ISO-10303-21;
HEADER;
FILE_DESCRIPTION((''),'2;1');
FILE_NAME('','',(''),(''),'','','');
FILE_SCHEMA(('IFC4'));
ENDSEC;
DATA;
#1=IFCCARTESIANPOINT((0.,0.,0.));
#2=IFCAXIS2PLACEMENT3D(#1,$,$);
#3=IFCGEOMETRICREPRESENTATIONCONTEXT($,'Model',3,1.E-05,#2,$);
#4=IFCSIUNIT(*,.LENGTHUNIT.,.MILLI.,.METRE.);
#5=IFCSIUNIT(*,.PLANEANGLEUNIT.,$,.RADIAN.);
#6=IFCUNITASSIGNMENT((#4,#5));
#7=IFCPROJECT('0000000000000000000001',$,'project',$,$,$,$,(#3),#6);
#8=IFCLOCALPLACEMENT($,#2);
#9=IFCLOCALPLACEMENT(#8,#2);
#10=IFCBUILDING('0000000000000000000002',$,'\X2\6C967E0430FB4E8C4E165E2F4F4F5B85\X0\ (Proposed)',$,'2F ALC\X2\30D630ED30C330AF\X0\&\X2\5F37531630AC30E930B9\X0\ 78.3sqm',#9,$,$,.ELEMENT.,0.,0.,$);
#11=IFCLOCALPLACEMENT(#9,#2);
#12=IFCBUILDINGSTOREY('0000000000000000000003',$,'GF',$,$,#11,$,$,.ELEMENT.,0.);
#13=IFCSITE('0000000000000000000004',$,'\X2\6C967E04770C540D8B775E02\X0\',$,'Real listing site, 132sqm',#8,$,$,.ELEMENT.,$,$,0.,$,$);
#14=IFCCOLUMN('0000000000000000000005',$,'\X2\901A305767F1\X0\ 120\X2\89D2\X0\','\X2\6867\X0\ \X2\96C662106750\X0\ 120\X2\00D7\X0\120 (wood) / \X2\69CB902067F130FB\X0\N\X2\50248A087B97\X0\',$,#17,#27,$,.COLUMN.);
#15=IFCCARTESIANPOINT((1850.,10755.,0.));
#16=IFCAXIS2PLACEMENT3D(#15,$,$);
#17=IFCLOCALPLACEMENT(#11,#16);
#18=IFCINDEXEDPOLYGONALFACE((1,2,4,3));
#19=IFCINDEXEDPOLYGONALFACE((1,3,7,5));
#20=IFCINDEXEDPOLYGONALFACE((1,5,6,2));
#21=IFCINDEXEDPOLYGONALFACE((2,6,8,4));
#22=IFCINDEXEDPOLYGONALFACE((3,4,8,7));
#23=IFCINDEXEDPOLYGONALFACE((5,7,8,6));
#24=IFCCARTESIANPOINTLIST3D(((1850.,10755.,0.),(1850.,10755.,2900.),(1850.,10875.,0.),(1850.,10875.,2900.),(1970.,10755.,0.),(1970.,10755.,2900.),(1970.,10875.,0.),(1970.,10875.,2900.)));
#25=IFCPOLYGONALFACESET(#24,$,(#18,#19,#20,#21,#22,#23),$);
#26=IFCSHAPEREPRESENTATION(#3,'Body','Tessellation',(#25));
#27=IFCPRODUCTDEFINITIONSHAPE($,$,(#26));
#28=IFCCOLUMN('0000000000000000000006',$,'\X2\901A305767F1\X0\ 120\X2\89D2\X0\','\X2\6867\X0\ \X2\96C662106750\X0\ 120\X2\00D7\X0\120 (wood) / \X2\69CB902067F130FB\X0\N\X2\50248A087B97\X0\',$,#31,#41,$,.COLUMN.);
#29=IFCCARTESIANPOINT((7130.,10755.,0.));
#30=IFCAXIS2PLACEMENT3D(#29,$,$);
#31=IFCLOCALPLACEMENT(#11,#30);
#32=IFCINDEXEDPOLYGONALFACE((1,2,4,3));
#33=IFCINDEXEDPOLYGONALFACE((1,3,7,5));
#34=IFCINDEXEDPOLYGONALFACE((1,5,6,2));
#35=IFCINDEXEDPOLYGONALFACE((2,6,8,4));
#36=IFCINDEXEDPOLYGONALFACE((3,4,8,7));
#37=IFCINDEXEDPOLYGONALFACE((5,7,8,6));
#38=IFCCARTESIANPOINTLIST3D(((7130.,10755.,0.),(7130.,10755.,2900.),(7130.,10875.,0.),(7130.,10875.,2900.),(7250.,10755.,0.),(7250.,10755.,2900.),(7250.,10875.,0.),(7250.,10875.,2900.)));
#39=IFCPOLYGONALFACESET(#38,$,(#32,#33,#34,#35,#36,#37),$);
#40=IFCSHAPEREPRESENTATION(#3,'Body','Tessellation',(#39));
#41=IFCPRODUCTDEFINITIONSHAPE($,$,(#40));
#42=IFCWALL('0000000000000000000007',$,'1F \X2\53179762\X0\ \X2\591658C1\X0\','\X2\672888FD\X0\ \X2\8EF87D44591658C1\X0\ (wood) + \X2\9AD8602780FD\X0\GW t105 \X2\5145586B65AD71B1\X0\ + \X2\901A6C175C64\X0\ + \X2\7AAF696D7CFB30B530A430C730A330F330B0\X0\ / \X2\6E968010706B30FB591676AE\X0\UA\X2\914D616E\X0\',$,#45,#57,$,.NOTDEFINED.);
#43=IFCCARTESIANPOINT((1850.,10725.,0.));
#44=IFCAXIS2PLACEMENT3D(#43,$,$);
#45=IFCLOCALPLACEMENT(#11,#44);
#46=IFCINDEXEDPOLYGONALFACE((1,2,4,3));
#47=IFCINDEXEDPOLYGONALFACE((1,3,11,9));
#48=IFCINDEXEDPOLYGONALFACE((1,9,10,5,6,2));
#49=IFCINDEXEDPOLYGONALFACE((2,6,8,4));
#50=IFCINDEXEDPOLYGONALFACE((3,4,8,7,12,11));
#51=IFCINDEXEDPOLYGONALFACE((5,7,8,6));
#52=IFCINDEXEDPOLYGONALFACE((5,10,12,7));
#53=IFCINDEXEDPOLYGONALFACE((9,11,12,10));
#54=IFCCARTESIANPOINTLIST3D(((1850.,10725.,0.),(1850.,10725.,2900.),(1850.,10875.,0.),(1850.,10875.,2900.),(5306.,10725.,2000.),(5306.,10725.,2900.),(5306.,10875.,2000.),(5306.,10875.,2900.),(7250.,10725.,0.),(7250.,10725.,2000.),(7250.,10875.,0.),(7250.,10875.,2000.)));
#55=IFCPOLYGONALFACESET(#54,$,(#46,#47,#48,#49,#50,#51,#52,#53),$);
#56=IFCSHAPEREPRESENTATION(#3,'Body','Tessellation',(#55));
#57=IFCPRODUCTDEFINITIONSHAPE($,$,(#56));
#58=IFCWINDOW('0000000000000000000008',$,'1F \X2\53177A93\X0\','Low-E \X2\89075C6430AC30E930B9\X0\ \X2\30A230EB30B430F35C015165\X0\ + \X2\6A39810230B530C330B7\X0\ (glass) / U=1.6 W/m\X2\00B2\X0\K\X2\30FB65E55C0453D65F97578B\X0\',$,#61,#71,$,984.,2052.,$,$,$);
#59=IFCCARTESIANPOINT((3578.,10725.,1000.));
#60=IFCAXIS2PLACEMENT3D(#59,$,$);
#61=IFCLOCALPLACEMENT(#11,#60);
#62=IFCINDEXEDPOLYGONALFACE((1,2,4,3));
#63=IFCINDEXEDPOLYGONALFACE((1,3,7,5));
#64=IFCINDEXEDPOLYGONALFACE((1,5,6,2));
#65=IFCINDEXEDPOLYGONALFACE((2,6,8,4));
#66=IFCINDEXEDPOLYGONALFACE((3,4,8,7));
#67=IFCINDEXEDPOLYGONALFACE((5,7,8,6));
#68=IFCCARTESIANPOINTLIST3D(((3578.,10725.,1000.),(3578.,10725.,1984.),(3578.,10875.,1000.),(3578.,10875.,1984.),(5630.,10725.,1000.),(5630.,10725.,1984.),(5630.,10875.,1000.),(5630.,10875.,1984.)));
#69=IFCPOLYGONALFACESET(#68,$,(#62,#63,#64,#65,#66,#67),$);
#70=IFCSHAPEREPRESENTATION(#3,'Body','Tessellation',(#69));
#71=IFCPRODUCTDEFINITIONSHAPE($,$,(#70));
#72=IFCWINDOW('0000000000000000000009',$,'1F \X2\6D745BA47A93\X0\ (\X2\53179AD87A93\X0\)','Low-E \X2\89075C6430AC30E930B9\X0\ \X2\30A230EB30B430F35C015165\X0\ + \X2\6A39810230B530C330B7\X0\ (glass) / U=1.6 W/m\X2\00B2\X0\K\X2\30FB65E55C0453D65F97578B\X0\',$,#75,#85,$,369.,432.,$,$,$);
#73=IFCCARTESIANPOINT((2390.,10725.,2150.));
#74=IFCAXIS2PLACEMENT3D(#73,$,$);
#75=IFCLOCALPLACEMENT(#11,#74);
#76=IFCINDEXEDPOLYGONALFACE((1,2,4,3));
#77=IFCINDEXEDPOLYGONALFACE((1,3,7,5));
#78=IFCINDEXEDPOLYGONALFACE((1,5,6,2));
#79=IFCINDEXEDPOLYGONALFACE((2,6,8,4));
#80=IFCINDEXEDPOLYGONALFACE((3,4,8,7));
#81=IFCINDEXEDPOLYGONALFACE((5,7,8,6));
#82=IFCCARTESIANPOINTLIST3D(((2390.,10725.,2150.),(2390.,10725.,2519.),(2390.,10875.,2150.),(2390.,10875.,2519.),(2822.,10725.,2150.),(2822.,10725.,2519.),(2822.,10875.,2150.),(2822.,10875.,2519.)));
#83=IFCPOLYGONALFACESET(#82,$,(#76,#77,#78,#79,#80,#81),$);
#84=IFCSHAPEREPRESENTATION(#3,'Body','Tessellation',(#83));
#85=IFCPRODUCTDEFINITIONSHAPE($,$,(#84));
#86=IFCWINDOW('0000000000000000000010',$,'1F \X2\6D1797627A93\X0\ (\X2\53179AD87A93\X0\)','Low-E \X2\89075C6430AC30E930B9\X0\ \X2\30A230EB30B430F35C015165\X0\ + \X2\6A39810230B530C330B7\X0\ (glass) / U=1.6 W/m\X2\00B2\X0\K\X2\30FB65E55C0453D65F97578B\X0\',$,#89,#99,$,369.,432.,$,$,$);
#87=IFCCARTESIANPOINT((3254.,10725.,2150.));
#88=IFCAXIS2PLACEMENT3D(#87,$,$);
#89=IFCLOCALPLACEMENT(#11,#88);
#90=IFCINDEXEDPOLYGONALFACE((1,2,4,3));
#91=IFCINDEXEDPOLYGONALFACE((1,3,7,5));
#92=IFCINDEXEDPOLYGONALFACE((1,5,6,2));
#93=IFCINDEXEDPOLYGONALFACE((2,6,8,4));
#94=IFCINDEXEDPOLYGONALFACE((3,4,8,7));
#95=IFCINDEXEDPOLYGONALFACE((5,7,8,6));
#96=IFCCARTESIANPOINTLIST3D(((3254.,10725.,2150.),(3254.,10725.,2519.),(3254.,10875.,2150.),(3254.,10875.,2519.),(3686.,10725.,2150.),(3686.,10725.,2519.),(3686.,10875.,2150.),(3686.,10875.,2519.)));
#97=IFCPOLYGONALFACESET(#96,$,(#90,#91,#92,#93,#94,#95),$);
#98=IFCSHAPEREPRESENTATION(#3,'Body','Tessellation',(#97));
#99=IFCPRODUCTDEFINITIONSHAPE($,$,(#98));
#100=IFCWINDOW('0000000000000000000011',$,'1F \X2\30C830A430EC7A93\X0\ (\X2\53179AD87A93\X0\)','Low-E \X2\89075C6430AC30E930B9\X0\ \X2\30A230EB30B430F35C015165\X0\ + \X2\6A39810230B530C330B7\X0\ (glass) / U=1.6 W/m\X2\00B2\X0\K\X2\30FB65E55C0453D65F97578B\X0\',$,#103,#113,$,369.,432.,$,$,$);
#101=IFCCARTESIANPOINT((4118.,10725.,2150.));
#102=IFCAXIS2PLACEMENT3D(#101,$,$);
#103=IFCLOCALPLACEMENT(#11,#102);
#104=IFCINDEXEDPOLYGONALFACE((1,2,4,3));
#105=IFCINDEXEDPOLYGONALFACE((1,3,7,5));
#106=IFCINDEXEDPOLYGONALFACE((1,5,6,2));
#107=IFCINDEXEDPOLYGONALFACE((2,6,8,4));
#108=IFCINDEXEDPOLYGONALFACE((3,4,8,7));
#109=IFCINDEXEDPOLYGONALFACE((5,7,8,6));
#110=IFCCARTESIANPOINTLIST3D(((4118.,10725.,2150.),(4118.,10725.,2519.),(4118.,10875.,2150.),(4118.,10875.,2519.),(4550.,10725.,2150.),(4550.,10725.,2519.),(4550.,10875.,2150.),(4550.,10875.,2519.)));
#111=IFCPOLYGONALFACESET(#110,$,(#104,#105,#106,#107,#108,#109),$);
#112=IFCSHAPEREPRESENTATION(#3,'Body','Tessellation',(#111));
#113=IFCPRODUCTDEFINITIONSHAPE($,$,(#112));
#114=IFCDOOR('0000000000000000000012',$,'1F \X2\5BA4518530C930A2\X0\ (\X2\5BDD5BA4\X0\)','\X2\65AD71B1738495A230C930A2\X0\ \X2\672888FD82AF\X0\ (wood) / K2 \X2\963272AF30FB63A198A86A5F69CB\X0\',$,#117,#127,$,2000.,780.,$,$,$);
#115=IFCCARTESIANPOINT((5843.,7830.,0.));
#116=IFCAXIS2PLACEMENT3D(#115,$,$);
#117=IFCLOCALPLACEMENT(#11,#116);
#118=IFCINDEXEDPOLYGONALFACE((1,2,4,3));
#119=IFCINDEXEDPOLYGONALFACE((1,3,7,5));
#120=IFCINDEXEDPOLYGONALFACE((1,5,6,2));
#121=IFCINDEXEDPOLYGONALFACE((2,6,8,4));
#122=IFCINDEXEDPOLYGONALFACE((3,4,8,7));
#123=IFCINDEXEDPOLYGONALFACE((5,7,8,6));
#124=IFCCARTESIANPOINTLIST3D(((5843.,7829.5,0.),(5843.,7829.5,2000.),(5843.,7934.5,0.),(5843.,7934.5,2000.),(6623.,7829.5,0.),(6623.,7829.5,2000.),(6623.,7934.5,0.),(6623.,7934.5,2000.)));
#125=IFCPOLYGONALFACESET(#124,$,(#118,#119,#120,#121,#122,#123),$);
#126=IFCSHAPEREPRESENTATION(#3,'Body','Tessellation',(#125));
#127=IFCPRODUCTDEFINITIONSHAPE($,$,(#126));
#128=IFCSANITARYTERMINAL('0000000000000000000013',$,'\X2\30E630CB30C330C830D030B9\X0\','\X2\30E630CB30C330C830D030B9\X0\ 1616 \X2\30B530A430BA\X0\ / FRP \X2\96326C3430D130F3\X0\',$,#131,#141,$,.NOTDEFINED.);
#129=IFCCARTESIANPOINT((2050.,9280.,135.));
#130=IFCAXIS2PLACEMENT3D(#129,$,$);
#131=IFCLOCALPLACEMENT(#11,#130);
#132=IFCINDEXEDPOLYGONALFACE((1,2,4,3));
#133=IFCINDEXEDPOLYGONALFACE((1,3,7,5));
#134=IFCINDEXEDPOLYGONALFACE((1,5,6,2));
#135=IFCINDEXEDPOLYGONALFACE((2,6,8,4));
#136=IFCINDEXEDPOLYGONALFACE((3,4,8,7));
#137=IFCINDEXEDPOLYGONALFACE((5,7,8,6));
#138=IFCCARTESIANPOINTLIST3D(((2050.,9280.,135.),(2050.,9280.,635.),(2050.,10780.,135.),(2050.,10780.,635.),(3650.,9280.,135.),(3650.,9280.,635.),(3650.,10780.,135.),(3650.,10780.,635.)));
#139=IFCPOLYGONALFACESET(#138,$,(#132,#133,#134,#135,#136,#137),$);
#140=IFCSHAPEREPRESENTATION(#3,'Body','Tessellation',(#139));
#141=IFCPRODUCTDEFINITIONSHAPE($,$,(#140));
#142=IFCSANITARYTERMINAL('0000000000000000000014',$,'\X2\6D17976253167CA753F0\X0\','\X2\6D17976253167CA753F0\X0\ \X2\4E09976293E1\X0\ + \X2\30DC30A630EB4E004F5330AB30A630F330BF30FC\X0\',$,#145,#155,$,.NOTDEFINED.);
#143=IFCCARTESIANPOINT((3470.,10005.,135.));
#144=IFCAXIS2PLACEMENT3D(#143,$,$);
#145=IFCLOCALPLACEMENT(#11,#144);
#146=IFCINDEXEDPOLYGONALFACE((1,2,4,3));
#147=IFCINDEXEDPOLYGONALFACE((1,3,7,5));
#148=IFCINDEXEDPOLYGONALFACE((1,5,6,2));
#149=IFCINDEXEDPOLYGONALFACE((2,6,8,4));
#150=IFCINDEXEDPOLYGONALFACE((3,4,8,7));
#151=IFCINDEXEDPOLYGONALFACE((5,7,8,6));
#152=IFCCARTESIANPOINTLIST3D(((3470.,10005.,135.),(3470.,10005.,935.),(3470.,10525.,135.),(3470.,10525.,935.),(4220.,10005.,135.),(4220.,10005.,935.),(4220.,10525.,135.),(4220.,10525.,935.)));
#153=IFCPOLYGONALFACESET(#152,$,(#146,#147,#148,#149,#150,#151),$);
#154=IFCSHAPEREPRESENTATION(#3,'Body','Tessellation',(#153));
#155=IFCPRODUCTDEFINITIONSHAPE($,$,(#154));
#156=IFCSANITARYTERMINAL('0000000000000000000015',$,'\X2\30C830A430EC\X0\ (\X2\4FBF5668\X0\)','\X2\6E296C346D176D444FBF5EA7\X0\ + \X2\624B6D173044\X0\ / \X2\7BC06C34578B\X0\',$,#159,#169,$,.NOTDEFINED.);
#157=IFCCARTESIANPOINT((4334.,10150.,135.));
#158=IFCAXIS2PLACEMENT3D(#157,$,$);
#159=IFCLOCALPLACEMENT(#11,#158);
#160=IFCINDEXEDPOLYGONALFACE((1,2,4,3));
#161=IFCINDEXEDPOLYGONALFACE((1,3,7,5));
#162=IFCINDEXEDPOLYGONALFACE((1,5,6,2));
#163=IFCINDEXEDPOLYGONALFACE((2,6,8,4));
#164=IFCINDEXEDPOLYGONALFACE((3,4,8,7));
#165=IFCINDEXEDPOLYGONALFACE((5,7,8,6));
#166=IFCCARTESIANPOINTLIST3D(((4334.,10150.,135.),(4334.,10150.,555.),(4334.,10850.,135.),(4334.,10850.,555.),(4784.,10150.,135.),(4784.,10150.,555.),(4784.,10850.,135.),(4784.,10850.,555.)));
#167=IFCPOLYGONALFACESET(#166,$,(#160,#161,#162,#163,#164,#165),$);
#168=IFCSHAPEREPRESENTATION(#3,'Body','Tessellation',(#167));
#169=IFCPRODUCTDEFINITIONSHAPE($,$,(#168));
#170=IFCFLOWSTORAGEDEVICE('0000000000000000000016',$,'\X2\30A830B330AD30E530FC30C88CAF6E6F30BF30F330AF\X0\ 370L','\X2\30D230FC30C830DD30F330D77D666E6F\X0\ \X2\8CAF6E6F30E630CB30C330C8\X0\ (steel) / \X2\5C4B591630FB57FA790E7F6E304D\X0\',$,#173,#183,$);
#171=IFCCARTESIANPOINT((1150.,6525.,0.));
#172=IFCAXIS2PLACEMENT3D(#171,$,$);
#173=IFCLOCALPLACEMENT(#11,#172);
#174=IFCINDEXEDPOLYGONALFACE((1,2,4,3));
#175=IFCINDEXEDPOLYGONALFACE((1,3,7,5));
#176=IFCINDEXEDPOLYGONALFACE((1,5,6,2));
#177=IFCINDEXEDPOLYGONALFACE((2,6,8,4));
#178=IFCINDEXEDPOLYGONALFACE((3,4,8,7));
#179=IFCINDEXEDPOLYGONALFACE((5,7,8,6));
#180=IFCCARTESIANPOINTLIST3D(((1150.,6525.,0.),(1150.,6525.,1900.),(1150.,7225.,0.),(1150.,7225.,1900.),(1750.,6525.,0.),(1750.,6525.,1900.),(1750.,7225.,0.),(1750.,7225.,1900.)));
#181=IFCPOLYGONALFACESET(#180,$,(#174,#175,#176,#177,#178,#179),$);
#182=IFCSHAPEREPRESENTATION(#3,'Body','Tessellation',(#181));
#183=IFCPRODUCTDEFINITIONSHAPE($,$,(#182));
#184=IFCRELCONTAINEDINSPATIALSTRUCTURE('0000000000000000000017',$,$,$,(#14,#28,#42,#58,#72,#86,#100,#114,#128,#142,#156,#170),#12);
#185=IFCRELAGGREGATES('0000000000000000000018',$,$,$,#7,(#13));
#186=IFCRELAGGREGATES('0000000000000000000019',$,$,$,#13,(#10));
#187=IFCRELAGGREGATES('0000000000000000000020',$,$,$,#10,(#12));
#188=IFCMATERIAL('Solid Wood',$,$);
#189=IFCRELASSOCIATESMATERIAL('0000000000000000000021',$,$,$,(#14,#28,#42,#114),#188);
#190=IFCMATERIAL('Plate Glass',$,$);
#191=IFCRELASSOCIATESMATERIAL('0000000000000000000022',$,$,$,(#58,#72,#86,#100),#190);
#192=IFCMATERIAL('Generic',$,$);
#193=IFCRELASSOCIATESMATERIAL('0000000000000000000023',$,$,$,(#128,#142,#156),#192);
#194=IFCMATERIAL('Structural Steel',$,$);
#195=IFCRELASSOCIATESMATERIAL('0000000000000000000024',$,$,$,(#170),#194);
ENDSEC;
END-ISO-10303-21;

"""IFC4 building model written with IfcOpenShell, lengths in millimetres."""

from ifc_helpers import new_model, si_unit, frame, frame_2d, origin, place, context, project, spatial, rectangle, extrude, material, element, fill, save


model = new_model("IFC4")

# Units and contexts
model_context = context("Model", 3, precision=1e-05, world=origin())
ifc_project = project(units=[si_unit("LENGTHUNIT", "METRE", prefix="MILLI"), si_unit("PLANEANGLEUNIT", "RADIAN")], contexts=[model_context])

# Site, building, storey
site_placement = place(None, origin())
site = spatial("IfcSite", under=ifc_project, at=site_placement, Name="沖縄県名護市", ObjectType="Real listing site, 132sqm", CompositionType="ELEMENT", RefElevation=0.0)
building_placement = place(site_placement, origin())
building = spatial("IfcBuilding", under=site, at=building_placement, Name="沖縄・二世帯住宅 (Proposed)", ObjectType="2F ALCブロック&強化ガラス 78.3sqm", CompositionType="ELEMENT", ElevationOfRefHeight=0.0, ElevationOfTerrain=0.0)
storey_placement = place(building_placement, origin())
storey = spatial("IfcBuildingStorey", under=building, at=storey_placement, Name="GF", CompositionType="ELEMENT", Elevation=0.0)

# Columns
ifc_material_1 = material(Name="Solid Wood")
column_1_placement = place(storey_placement, frame((1850.0, 10755.0, 0.0)))
element("IfcColumn", 1, at=column_1_placement, inside=storey, material=ifc_material_1, Name="通し柱 120角", Description="桧 集成材 120×120 (wood) / 構造柱・N値計算", PredefinedType="COLUMN", context=model_context, shape_type="SweptSolid", body=[
    extrude(rectangle(XDim=120.0, YDim=120.0, at=frame_2d((60.0, 60.0))), frame((1850.0, 10755.0, 0.0)), (0.0, 0.0, 1.0), 2900.0),
])
column_2_placement = place(storey_placement, frame((7130.0, 10755.0, 0.0)))
element("IfcColumn", 2, at=column_2_placement, inside=storey, material=ifc_material_1, Name="通し柱 120角", Description="桧 集成材 120×120 (wood) / 構造柱・N値計算", PredefinedType="COLUMN", context=model_context, shape_type="SweptSolid", body=[
    extrude(rectangle(XDim=120.0, YDim=120.0, at=frame_2d((60.0, 60.0))), frame((7130.0, 10755.0, 0.0)), (0.0, 0.0, 1.0), 2900.0),
])

# Wall, openings, windows
wall_1_placement = place(storey_placement, frame((1850.0, 10725.0, 0.0)))
wall_1 = element("IfcWall", 3, at=wall_1_placement, inside=storey, material=ifc_material_1, Name="1F 北面 外壁", Description="木製 軸組外壁 (wood) + 高性能GW t105 充填断熱 + 通気層 + 窯業系サイディング / 準耐火・外皮UA配慮", PredefinedType="NOTDEFINED", context=model_context, shape_type="SweptSolid", body=[
    extrude(rectangle(XDim=5400.0, YDim=150.0, at=frame_2d((2700.0, 75.0))), frame((1850.0, 10725.0, 0.0)), (0.0, 0.0, 1.0), 2900.0),
])
opening_1_placement = place(storey_placement, frame((3578.0, 10725.0, 1000.0)))
opening_1 = element("IfcOpeningElement", 4, at=opening_1_placement, cuts=wall_1, PredefinedType="NOTDEFINED", context=model_context, shape_type="SweptSolid", body=[
    extrude(rectangle(XDim=2052.0, YDim=150.0, at=frame_2d((1026.0, 75.0))), frame((3578.0, 10725.0, 1000.0)), (0.0, 0.0, 1.0), 984.0),
])
opening_2_placement = place(storey_placement, frame((2390.0, 10725.0, 2150.0)))
opening_2 = element("IfcOpeningElement", 5, at=opening_2_placement, cuts=wall_1, PredefinedType="NOTDEFINED", context=model_context, shape_type="SweptSolid", body=[
    extrude(rectangle(XDim=432.0, YDim=150.0, at=frame_2d((216.0, 75.0))), frame((2390.0, 10725.0, 2150.0)), (0.0, 0.0, 1.0), 369.0),
])
opening_3_placement = place(storey_placement, frame((3254.0, 10725.0, 2150.0)))
opening_3 = element("IfcOpeningElement", 6, at=opening_3_placement, cuts=wall_1, PredefinedType="NOTDEFINED", context=model_context, shape_type="SweptSolid", body=[
    extrude(rectangle(XDim=432.0, YDim=150.0, at=frame_2d((216.0, 75.0))), frame((3254.0, 10725.0, 2150.0)), (0.0, 0.0, 1.0), 369.0),
])
opening_4_placement = place(storey_placement, frame((4118.0, 10725.0, 2150.0)))
opening_4 = element("IfcOpeningElement", 7, at=opening_4_placement, cuts=wall_1, PredefinedType="NOTDEFINED", context=model_context, shape_type="SweptSolid", body=[
    extrude(rectangle(XDim=432.0, YDim=150.0, at=frame_2d((216.0, 75.0))), frame((4118.0, 10725.0, 2150.0)), (0.0, 0.0, 1.0), 369.0),
])
ifc_material_2 = material(Name="Plate Glass")
window_1_placement = place(storey_placement, frame((3578.0, 10725.0, 1000.0)))
window_1 = element("IfcWindow", 8, at=window_1_placement, inside=storey, material=ifc_material_2, Name="1F 北窓", Description="Low-E 複層ガラス アルゴン封入 + 樹脂サッシ (glass) / U=1.6 W/m²K・日射取得型", OverallHeight=984.0, OverallWidth=2052.0, context=model_context, shape_type="SweptSolid", body=[
    extrude(rectangle(XDim=2052.0, YDim=150.0, at=frame_2d((1026.0, 75.0))), frame((3578.0, 10725.0, 1000.0)), (0.0, 0.0, 1.0), 984.0),
])
fill(opening_1, window_1)
window_2_placement = place(storey_placement, frame((2390.0, 10725.0, 2150.0)))
window_2 = element("IfcWindow", 9, at=window_2_placement, inside=storey, material=ifc_material_2, Name="1F 浴室窓 (北高窓)", Description="Low-E 複層ガラス アルゴン封入 + 樹脂サッシ (glass) / U=1.6 W/m²K・日射取得型", OverallHeight=369.0, OverallWidth=432.0, context=model_context, shape_type="SweptSolid", body=[
    extrude(rectangle(XDim=432.0, YDim=150.0, at=frame_2d((216.0, 75.0))), frame((2390.0, 10725.0, 2150.0)), (0.0, 0.0, 1.0), 369.0),
])
fill(opening_2, window_2)
window_3_placement = place(storey_placement, frame((3254.0, 10725.0, 2150.0)))
window_3 = element("IfcWindow", 10, at=window_3_placement, inside=storey, material=ifc_material_2, Name="1F 洗面窓 (北高窓)", Description="Low-E 複層ガラス アルゴン封入 + 樹脂サッシ (glass) / U=1.6 W/m²K・日射取得型", OverallHeight=369.0, OverallWidth=432.0, context=model_context, shape_type="SweptSolid", body=[
    extrude(rectangle(XDim=432.0, YDim=150.0, at=frame_2d((216.0, 75.0))), frame((3254.0, 10725.0, 2150.0)), (0.0, 0.0, 1.0), 369.0),
])
fill(opening_3, window_3)
window_4_placement = place(storey_placement, frame((4118.0, 10725.0, 2150.0)))
window_4 = element("IfcWindow", 11, at=window_4_placement, inside=storey, material=ifc_material_2, Name="1F トイレ窓 (北高窓)", Description="Low-E 複層ガラス アルゴン封入 + 樹脂サッシ (glass) / U=1.6 W/m²K・日射取得型", OverallHeight=369.0, OverallWidth=432.0, context=model_context, shape_type="SweptSolid", body=[
    extrude(rectangle(XDim=432.0, YDim=150.0, at=frame_2d((216.0, 75.0))), frame((4118.0, 10725.0, 2150.0)), (0.0, 0.0, 1.0), 369.0),
])
fill(opening_4, window_4)

# Door
door_1_placement = place(storey_placement, frame((5843.0, 7830.0, 0.0)))
element("IfcDoor", 12, at=door_1_placement, inside=storey, material=ifc_material_1, Name="1F 室内ドア (寝室)", Description="断熱玄関ドア 木製芯 (wood) / K2 防犯・採風機構", OverallHeight=2000.0, OverallWidth=780.0, context=model_context, shape_type="SweptSolid", body=[
    extrude(rectangle(XDim=780.0, YDim=105.0, at=frame_2d((390.0, 52.0))), frame((5843.0, 7830.0, 0.0)), (0.0, 0.0, 1.0), 2000.0),
])

# Sanitary terminals
ifc_material_3 = material(Name="Generic")
sanitary_terminal_1_placement = place(storey_placement, frame((2050.0, 9280.0, 135.0)))
element("IfcSanitaryTerminal", 13, at=sanitary_terminal_1_placement, inside=storey, material=ifc_material_3, Name="ユニットバス", Description="ユニットバス 1616 サイズ / FRP 防水パン", PredefinedType="NOTDEFINED", context=model_context, shape_type="SweptSolid", body=[
    extrude(rectangle(XDim=1600.0, YDim=1500.0, at=frame_2d((800.0, 750.0))), frame((2050.0, 9280.0, 135.0)), (0.0, 0.0, 1.0), 500.0),
])
sanitary_terminal_2_placement = place(storey_placement, frame((3470.0, 10005.0, 135.0)))
element("IfcSanitaryTerminal", 14, at=sanitary_terminal_2_placement, inside=storey, material=ifc_material_3, Name="洗面化粧台", Description="洗面化粧台 三面鏡 + ボウル一体カウンター", PredefinedType="NOTDEFINED", context=model_context, shape_type="SweptSolid", body=[
    extrude(rectangle(XDim=750.0, YDim=520.0, at=frame_2d((375.0, 260.0))), frame((3470.0, 10005.0, 135.0)), (0.0, 0.0, 1.0), 800.0),
])
sanitary_terminal_3_placement = place(storey_placement, frame((4334.0, 10150.0, 135.0)))
element("IfcSanitaryTerminal", 15, at=sanitary_terminal_3_placement, inside=storey, material=ifc_material_3, Name="トイレ (便器)", Description="温水洗浄便座 + 手洗い / 節水型", PredefinedType="NOTDEFINED", context=model_context, shape_type="SweptSolid", body=[
    extrude(rectangle(XDim=450.0, YDim=700.0, at=frame_2d((225.0, 350.0))), frame((4334.0, 10150.0, 135.0)), (0.0, 0.0, 1.0), 420.0),
])

# Flow storage device
ifc_material_4 = material(Name="Structural Steel")
flow_storage_device_placement = place(storey_placement, frame((1150.0, 6525.0, 0.0)))
element("IfcFlowStorageDevice", 16, at=flow_storage_device_placement, inside=storey, material=ifc_material_4, Name="エコキュート貯湯タンク 370L", Description="ヒートポンプ給湯 貯湯ユニット (steel) / 屋外・基礎置き", context=model_context, shape_type="SweptSolid", body=[
    extrude(rectangle(XDim=600.0, YDim=700.0, at=frame_2d((300.0, 350.0))), frame((1150.0, 6525.0, 0.0)), (0.0, 0.0, 1.0), 1900.0),
])

save(model, "model.ifc")
